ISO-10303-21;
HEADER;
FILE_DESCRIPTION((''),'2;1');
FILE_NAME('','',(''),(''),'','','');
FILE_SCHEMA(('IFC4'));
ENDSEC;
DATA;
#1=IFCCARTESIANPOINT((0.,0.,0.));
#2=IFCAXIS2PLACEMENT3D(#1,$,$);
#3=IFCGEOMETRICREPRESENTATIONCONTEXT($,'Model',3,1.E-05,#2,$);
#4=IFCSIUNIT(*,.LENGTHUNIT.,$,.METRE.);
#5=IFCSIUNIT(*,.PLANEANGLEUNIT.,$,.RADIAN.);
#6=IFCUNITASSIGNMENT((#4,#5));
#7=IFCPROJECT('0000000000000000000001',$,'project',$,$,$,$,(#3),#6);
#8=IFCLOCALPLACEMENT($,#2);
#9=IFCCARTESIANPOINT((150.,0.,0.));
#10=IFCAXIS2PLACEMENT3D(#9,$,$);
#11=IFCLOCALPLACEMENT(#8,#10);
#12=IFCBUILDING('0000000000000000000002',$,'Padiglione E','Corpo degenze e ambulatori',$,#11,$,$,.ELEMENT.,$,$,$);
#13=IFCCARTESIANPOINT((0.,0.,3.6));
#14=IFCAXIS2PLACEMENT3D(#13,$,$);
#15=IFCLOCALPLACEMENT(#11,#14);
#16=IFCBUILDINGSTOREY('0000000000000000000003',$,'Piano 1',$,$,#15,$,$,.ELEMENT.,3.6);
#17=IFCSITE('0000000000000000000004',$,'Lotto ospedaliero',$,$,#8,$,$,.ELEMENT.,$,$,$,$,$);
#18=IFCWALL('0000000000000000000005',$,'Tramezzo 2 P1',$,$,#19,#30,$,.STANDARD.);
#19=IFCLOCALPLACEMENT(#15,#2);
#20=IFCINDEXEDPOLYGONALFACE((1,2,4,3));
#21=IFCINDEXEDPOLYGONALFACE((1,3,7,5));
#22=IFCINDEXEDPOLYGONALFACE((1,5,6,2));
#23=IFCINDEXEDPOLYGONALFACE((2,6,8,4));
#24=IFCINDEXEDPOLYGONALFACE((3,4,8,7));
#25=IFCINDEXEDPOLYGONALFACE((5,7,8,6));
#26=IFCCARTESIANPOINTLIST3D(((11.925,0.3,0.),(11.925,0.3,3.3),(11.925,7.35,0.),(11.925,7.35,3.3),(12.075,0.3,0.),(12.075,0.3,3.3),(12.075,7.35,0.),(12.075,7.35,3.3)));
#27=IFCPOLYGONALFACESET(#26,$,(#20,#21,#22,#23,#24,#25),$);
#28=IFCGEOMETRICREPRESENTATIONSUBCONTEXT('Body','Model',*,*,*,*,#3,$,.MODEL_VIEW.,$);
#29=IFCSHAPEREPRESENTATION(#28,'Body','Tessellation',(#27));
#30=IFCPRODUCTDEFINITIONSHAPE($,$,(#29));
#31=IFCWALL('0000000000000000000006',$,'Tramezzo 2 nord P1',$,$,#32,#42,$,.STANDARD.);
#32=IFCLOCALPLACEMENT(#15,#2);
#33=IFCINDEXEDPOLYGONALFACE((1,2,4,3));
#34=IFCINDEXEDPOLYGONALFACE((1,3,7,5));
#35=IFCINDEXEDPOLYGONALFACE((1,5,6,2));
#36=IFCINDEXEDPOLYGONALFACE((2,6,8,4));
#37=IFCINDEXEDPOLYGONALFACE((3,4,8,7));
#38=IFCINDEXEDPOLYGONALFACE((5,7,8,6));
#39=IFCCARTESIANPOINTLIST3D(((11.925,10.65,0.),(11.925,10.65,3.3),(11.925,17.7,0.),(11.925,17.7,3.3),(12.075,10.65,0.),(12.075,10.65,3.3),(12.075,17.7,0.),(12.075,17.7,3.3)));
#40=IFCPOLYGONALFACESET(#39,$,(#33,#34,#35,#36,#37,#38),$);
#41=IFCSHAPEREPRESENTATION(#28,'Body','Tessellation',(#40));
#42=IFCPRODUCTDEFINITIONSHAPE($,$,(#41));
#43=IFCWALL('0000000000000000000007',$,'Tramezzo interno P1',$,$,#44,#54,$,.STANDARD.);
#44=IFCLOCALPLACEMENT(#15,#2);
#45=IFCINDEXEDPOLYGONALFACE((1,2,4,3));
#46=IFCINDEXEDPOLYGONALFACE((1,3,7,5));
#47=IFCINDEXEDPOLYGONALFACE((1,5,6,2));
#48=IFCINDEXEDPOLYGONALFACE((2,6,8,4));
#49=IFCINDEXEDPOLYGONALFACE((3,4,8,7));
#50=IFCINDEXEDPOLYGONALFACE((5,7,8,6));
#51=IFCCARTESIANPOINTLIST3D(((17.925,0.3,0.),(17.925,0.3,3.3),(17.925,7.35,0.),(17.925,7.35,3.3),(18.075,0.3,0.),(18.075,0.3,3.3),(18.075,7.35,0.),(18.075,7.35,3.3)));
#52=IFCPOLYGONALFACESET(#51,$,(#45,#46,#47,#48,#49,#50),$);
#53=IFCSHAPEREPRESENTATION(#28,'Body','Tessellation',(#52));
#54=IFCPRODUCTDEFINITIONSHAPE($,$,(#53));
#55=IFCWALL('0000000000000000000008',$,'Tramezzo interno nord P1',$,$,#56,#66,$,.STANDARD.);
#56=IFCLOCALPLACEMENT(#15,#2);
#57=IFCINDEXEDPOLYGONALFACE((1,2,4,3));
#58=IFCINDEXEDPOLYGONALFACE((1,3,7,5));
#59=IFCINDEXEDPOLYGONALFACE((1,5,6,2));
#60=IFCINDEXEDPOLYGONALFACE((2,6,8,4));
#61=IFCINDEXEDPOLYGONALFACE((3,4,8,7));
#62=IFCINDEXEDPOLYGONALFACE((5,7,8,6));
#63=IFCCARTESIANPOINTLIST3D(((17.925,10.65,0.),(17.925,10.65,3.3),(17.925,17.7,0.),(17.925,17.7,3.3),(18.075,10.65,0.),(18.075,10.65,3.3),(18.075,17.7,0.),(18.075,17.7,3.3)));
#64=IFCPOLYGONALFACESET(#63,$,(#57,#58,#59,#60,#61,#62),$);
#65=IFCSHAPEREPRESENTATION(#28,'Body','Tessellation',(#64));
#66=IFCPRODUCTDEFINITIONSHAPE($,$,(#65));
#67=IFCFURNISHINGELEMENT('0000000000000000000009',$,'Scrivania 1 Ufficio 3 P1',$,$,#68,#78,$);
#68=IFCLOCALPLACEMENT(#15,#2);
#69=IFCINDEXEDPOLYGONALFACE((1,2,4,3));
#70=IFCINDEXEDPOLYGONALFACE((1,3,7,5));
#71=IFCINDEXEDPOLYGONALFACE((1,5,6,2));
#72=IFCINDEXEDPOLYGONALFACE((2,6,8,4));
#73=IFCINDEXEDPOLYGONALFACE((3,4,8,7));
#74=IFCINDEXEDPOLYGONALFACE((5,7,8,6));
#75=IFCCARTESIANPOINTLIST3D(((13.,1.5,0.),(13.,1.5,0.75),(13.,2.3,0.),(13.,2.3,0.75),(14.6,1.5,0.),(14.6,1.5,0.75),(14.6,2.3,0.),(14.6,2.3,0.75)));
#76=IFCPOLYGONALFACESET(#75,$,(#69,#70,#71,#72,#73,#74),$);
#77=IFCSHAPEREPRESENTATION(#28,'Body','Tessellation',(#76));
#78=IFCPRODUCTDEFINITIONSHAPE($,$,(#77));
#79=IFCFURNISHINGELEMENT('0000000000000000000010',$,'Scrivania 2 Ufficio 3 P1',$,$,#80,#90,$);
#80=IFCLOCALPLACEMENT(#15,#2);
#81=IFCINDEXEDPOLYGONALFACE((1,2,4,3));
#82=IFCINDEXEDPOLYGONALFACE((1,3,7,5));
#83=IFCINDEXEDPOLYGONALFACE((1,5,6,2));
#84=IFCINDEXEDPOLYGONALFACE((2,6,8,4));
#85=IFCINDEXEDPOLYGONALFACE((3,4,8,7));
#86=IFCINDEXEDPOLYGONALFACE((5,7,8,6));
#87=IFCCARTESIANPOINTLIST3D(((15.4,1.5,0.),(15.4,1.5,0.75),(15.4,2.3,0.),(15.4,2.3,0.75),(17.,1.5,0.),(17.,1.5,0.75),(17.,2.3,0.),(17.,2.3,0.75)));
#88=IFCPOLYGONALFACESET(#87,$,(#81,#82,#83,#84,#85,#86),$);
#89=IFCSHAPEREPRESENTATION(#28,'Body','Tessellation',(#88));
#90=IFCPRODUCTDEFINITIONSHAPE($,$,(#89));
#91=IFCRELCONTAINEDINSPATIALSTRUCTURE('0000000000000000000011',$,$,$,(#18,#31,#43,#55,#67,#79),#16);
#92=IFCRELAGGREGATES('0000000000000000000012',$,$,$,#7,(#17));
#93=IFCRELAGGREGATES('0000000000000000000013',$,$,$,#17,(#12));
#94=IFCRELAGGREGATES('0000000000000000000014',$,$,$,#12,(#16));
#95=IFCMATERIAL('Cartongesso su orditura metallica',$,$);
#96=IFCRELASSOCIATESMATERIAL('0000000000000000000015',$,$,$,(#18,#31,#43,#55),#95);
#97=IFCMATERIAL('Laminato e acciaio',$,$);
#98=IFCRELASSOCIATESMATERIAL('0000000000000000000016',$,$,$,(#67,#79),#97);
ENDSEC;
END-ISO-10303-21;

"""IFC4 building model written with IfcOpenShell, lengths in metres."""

from ifc_helpers import new_model, si_unit, frame, frame_2d, origin, place, context, subcontext, project, spatial, rectangle, extrude, material, element, save


model = new_model("IFC4")

# Units and contexts
model_context = context("Model", 3, precision=1e-05, world=origin())
body_context = subcontext(model_context, "Body", "Model", "MODEL_VIEW")
ifc_project = project(units=[si_unit("LENGTHUNIT", "METRE"), si_unit("PLANEANGLEUNIT", "RADIAN")], contexts=[model_context])

# Site, building, storey
site_placement = place(None, origin())
site = spatial("IfcSite", under=ifc_project, at=site_placement, Name="Lotto ospedaliero", CompositionType="ELEMENT")
building_placement = place(site_placement, frame((150.0, 0.0, 0.0)))
building = spatial("IfcBuilding", under=site, at=building_placement, Name="Padiglione E", Description="Corpo degenze e ambulatori", CompositionType="ELEMENT")
storey_placement = place(building_placement, frame((0.0, 0.0, 3.6)))
storey = spatial("IfcBuildingStorey", under=building, at=storey_placement, Name="Piano 1", CompositionType="ELEMENT", Elevation=3.6)

# Walls
ifc_material_1 = material(Name="Cartongesso su orditura metallica")
for number, where, name in (
    (1, (11.925, 0.3, 0.0), "Tramezzo 2 P1"),
    (2, (11.925, 10.65, 0.0), "Tramezzo 2 nord P1"),
    (3, (17.925, 0.3, 0.0), "Tramezzo interno P1"),
    (4, (17.925, 10.65, 0.0), "Tramezzo interno nord P1"),
):
    element("IfcWall", number, at=place(storey_placement, frame(where)), inside=storey, material=ifc_material_1, Name=name, PredefinedType="STANDARD", context=body_context, shape_type="SweptSolid", body=[
        extrude(rectangle(XDim=0.15, YDim=7.05, at=frame_2d((0.075, 3.525))), origin(), (0.0, 0.0, 1.0), 3.3),
    ])

# Furnishing elements
ifc_material_2 = material(Name="Laminato e acciaio")
for number, where, name in (
    (5, (13.0, 1.5, 0.0), "Scrivania 1 Ufficio 3 P1"),
    (6, (15.4, 1.5, 0.0), "Scrivania 2 Ufficio 3 P1"),
):
    element("IfcFurnishingElement", number, at=place(storey_placement, frame(where)), inside=storey, material=ifc_material_2, Name=name, context=body_context, shape_type="SweptSolid", body=[
        extrude(rectangle(XDim=1.6, YDim=0.8, at=frame_2d((0.8, 0.4))), origin(), (0.0, 0.0, 1.0), 0.75),
    ])

save(model, "model.ifc")
